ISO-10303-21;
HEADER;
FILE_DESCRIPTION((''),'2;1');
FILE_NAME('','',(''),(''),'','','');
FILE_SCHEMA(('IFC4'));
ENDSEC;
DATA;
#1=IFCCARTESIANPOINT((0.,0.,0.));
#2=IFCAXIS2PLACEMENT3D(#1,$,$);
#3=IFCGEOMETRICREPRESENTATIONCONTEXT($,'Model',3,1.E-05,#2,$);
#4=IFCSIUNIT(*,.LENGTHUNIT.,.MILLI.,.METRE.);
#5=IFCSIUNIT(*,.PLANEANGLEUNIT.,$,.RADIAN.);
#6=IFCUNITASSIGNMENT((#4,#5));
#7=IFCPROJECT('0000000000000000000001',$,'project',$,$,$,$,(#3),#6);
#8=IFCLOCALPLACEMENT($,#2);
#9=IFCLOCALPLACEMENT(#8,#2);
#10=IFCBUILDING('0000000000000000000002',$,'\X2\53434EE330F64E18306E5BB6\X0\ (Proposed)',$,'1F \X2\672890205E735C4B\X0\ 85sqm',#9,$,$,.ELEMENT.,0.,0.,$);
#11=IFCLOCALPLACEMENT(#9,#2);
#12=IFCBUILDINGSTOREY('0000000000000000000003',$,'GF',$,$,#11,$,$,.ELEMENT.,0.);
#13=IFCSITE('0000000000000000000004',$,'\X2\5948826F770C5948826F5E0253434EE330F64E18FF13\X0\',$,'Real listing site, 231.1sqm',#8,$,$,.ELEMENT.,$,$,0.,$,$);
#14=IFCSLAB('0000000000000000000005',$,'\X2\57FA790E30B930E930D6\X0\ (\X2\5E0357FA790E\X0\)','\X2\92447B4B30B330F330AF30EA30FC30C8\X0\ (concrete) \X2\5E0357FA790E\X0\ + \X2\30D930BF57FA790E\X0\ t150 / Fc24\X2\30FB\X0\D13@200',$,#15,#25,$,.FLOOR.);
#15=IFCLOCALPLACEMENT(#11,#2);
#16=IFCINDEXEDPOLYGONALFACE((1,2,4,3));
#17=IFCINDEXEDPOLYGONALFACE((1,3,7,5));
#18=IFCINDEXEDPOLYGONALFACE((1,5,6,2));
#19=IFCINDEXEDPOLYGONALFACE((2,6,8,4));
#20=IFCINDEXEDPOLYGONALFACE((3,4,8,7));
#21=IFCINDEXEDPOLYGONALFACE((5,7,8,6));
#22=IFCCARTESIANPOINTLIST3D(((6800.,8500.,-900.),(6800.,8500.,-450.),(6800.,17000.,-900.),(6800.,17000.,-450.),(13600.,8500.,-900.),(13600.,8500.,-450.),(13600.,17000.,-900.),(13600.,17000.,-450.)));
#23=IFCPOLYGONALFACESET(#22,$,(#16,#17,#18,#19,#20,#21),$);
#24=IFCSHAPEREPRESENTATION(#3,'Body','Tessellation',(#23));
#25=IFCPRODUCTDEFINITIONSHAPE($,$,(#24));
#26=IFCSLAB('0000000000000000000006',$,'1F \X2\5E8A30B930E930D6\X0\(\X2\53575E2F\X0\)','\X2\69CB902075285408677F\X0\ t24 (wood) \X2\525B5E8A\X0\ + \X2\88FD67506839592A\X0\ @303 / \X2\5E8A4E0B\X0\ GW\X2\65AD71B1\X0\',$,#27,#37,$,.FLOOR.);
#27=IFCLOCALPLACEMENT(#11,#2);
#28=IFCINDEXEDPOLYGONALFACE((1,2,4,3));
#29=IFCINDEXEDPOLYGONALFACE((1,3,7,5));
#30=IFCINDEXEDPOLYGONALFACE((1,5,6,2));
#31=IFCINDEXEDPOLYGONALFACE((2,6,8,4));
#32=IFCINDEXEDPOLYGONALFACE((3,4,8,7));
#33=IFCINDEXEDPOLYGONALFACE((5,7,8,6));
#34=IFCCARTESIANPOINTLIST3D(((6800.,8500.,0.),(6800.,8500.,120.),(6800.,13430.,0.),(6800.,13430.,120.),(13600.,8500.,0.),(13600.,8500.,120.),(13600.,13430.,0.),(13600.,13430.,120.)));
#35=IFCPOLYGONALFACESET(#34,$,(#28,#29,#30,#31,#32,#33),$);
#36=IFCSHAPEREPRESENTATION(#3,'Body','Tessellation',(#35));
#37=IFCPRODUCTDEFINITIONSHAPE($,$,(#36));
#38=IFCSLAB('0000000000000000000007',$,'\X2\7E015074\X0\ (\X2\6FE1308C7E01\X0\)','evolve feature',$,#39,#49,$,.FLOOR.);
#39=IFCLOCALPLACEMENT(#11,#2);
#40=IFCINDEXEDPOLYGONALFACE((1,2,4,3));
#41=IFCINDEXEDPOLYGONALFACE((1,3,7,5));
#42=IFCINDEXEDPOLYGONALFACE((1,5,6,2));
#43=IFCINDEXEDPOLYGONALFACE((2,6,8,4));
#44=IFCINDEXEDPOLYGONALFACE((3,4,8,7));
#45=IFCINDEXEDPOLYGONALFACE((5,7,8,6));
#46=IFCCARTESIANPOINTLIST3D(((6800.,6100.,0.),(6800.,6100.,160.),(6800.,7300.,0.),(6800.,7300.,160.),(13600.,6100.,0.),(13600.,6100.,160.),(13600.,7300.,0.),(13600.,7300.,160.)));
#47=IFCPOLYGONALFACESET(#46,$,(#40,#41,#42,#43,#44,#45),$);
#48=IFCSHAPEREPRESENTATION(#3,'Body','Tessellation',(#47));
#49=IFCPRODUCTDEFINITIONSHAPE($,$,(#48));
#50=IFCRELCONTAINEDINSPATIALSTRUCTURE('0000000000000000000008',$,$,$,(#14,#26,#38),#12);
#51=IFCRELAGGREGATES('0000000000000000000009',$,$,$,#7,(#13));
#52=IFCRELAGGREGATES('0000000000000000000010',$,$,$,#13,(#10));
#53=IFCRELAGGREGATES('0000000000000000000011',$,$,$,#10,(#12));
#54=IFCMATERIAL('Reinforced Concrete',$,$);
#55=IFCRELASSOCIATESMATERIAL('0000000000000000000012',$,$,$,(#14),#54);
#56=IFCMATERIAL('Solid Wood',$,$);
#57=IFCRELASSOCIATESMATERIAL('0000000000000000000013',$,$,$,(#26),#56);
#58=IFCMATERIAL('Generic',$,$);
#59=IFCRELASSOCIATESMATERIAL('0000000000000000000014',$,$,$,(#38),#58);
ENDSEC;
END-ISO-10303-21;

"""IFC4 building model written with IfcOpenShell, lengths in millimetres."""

from ifc_helpers import new_model, si_unit, frame, frame_2d, origin, place, context, project, spatial, rectangle, extrude, material, element, save


model = new_model("IFC4")

# Units and contexts
model_context = context("Model", 3, precision=1e-05, world=origin())
ifc_project = project(units=[si_unit("LENGTHUNIT", "METRE", prefix="MILLI"), si_unit("PLANEANGLEUNIT", "RADIAN")], contexts=[model_context])

# Site, building, storey
site_placement = place(None, origin())
site = spatial("IfcSite", under=ifc_project, at=site_placement, Name="奈良県奈良市千代ヶ丘３", ObjectType="Real listing site, 231.1sqm", CompositionType="ELEMENT", RefElevation=0.0)
building_placement = place(site_placement, origin())
building = spatial("IfcBuilding", under=site, at=building_placement, Name="千代ヶ丘の家 (Proposed)", ObjectType="1F 木造平屋 85sqm", CompositionType="ELEMENT", ElevationOfRefHeight=0.0, ElevationOfTerrain=0.0)
storey_placement = place(building_placement, origin())
storey = spatial("IfcBuildingStorey", under=building, at=storey_placement, Name="GF", CompositionType="ELEMENT", Elevation=0.0)

# Slabs
ifc_material_1 = material(Name="Reinforced Concrete")
slab_1_placement = place(storey_placement, frame((3400.0, 4250.0, -450.0)))
element("IfcSlab", 1, at=slab_1_placement, inside=storey, material=ifc_material_1, Name="基礎スラブ (布基礎)", Description="鉄筋コンクリート (concrete) 布基礎 + ベタ基礎 t150 / Fc24・D13@200", PredefinedType="FLOOR", context=model_context, shape_type="SweptSolid", body=[
    extrude(rectangle(XDim=6800.0, YDim=8500.0, at=frame_2d((3400.0, 4250.0))), frame((3400.0, 4250.0, -450.0)), (0.0, 0.0, 1.0), 450.0),
])
ifc_material_2 = material(Name="Solid Wood")
slab_2_placement = place(storey_placement, frame((3400.0, 4250.0, 0.0)))
element("IfcSlab", 2, at=slab_2_placement, inside=storey, material=ifc_material_2, Name="1F 床スラブ(南帯)", Description="構造用合板 t24 (wood) 剛床 + 製材根太 @303 / 床下 GW断熱", PredefinedType="FLOOR", context=model_context, shape_type="SweptSolid", body=[
    extrude(rectangle(XDim=6800.0, YDim=4930.0, at=frame_2d((3400.0, 2465.0))), frame((3400.0, 4250.0, 0.0)), (0.0, 0.0, 1.0), 120.0),
])
ifc_material_3 = material(Name="Generic")
slab_3_placement = place(storey_placement, frame((3400.0, 3050.0, 0.0)))
element("IfcSlab", 3, at=slab_3_placement, inside=storey, material=ifc_material_3, Name="縁側 (濡れ縁)", Description="evolve feature", PredefinedType="FLOOR", context=model_context, shape_type="SweptSolid", body=[
    extrude(rectangle(XDim=6800.0, YDim=1200.0, at=frame_2d((3400.0, 600.0))), frame((3400.0, 3050.0, 0.0)), (0.0, 0.0, 1.0), 160.0),
])

save(model, "model.ifc")
